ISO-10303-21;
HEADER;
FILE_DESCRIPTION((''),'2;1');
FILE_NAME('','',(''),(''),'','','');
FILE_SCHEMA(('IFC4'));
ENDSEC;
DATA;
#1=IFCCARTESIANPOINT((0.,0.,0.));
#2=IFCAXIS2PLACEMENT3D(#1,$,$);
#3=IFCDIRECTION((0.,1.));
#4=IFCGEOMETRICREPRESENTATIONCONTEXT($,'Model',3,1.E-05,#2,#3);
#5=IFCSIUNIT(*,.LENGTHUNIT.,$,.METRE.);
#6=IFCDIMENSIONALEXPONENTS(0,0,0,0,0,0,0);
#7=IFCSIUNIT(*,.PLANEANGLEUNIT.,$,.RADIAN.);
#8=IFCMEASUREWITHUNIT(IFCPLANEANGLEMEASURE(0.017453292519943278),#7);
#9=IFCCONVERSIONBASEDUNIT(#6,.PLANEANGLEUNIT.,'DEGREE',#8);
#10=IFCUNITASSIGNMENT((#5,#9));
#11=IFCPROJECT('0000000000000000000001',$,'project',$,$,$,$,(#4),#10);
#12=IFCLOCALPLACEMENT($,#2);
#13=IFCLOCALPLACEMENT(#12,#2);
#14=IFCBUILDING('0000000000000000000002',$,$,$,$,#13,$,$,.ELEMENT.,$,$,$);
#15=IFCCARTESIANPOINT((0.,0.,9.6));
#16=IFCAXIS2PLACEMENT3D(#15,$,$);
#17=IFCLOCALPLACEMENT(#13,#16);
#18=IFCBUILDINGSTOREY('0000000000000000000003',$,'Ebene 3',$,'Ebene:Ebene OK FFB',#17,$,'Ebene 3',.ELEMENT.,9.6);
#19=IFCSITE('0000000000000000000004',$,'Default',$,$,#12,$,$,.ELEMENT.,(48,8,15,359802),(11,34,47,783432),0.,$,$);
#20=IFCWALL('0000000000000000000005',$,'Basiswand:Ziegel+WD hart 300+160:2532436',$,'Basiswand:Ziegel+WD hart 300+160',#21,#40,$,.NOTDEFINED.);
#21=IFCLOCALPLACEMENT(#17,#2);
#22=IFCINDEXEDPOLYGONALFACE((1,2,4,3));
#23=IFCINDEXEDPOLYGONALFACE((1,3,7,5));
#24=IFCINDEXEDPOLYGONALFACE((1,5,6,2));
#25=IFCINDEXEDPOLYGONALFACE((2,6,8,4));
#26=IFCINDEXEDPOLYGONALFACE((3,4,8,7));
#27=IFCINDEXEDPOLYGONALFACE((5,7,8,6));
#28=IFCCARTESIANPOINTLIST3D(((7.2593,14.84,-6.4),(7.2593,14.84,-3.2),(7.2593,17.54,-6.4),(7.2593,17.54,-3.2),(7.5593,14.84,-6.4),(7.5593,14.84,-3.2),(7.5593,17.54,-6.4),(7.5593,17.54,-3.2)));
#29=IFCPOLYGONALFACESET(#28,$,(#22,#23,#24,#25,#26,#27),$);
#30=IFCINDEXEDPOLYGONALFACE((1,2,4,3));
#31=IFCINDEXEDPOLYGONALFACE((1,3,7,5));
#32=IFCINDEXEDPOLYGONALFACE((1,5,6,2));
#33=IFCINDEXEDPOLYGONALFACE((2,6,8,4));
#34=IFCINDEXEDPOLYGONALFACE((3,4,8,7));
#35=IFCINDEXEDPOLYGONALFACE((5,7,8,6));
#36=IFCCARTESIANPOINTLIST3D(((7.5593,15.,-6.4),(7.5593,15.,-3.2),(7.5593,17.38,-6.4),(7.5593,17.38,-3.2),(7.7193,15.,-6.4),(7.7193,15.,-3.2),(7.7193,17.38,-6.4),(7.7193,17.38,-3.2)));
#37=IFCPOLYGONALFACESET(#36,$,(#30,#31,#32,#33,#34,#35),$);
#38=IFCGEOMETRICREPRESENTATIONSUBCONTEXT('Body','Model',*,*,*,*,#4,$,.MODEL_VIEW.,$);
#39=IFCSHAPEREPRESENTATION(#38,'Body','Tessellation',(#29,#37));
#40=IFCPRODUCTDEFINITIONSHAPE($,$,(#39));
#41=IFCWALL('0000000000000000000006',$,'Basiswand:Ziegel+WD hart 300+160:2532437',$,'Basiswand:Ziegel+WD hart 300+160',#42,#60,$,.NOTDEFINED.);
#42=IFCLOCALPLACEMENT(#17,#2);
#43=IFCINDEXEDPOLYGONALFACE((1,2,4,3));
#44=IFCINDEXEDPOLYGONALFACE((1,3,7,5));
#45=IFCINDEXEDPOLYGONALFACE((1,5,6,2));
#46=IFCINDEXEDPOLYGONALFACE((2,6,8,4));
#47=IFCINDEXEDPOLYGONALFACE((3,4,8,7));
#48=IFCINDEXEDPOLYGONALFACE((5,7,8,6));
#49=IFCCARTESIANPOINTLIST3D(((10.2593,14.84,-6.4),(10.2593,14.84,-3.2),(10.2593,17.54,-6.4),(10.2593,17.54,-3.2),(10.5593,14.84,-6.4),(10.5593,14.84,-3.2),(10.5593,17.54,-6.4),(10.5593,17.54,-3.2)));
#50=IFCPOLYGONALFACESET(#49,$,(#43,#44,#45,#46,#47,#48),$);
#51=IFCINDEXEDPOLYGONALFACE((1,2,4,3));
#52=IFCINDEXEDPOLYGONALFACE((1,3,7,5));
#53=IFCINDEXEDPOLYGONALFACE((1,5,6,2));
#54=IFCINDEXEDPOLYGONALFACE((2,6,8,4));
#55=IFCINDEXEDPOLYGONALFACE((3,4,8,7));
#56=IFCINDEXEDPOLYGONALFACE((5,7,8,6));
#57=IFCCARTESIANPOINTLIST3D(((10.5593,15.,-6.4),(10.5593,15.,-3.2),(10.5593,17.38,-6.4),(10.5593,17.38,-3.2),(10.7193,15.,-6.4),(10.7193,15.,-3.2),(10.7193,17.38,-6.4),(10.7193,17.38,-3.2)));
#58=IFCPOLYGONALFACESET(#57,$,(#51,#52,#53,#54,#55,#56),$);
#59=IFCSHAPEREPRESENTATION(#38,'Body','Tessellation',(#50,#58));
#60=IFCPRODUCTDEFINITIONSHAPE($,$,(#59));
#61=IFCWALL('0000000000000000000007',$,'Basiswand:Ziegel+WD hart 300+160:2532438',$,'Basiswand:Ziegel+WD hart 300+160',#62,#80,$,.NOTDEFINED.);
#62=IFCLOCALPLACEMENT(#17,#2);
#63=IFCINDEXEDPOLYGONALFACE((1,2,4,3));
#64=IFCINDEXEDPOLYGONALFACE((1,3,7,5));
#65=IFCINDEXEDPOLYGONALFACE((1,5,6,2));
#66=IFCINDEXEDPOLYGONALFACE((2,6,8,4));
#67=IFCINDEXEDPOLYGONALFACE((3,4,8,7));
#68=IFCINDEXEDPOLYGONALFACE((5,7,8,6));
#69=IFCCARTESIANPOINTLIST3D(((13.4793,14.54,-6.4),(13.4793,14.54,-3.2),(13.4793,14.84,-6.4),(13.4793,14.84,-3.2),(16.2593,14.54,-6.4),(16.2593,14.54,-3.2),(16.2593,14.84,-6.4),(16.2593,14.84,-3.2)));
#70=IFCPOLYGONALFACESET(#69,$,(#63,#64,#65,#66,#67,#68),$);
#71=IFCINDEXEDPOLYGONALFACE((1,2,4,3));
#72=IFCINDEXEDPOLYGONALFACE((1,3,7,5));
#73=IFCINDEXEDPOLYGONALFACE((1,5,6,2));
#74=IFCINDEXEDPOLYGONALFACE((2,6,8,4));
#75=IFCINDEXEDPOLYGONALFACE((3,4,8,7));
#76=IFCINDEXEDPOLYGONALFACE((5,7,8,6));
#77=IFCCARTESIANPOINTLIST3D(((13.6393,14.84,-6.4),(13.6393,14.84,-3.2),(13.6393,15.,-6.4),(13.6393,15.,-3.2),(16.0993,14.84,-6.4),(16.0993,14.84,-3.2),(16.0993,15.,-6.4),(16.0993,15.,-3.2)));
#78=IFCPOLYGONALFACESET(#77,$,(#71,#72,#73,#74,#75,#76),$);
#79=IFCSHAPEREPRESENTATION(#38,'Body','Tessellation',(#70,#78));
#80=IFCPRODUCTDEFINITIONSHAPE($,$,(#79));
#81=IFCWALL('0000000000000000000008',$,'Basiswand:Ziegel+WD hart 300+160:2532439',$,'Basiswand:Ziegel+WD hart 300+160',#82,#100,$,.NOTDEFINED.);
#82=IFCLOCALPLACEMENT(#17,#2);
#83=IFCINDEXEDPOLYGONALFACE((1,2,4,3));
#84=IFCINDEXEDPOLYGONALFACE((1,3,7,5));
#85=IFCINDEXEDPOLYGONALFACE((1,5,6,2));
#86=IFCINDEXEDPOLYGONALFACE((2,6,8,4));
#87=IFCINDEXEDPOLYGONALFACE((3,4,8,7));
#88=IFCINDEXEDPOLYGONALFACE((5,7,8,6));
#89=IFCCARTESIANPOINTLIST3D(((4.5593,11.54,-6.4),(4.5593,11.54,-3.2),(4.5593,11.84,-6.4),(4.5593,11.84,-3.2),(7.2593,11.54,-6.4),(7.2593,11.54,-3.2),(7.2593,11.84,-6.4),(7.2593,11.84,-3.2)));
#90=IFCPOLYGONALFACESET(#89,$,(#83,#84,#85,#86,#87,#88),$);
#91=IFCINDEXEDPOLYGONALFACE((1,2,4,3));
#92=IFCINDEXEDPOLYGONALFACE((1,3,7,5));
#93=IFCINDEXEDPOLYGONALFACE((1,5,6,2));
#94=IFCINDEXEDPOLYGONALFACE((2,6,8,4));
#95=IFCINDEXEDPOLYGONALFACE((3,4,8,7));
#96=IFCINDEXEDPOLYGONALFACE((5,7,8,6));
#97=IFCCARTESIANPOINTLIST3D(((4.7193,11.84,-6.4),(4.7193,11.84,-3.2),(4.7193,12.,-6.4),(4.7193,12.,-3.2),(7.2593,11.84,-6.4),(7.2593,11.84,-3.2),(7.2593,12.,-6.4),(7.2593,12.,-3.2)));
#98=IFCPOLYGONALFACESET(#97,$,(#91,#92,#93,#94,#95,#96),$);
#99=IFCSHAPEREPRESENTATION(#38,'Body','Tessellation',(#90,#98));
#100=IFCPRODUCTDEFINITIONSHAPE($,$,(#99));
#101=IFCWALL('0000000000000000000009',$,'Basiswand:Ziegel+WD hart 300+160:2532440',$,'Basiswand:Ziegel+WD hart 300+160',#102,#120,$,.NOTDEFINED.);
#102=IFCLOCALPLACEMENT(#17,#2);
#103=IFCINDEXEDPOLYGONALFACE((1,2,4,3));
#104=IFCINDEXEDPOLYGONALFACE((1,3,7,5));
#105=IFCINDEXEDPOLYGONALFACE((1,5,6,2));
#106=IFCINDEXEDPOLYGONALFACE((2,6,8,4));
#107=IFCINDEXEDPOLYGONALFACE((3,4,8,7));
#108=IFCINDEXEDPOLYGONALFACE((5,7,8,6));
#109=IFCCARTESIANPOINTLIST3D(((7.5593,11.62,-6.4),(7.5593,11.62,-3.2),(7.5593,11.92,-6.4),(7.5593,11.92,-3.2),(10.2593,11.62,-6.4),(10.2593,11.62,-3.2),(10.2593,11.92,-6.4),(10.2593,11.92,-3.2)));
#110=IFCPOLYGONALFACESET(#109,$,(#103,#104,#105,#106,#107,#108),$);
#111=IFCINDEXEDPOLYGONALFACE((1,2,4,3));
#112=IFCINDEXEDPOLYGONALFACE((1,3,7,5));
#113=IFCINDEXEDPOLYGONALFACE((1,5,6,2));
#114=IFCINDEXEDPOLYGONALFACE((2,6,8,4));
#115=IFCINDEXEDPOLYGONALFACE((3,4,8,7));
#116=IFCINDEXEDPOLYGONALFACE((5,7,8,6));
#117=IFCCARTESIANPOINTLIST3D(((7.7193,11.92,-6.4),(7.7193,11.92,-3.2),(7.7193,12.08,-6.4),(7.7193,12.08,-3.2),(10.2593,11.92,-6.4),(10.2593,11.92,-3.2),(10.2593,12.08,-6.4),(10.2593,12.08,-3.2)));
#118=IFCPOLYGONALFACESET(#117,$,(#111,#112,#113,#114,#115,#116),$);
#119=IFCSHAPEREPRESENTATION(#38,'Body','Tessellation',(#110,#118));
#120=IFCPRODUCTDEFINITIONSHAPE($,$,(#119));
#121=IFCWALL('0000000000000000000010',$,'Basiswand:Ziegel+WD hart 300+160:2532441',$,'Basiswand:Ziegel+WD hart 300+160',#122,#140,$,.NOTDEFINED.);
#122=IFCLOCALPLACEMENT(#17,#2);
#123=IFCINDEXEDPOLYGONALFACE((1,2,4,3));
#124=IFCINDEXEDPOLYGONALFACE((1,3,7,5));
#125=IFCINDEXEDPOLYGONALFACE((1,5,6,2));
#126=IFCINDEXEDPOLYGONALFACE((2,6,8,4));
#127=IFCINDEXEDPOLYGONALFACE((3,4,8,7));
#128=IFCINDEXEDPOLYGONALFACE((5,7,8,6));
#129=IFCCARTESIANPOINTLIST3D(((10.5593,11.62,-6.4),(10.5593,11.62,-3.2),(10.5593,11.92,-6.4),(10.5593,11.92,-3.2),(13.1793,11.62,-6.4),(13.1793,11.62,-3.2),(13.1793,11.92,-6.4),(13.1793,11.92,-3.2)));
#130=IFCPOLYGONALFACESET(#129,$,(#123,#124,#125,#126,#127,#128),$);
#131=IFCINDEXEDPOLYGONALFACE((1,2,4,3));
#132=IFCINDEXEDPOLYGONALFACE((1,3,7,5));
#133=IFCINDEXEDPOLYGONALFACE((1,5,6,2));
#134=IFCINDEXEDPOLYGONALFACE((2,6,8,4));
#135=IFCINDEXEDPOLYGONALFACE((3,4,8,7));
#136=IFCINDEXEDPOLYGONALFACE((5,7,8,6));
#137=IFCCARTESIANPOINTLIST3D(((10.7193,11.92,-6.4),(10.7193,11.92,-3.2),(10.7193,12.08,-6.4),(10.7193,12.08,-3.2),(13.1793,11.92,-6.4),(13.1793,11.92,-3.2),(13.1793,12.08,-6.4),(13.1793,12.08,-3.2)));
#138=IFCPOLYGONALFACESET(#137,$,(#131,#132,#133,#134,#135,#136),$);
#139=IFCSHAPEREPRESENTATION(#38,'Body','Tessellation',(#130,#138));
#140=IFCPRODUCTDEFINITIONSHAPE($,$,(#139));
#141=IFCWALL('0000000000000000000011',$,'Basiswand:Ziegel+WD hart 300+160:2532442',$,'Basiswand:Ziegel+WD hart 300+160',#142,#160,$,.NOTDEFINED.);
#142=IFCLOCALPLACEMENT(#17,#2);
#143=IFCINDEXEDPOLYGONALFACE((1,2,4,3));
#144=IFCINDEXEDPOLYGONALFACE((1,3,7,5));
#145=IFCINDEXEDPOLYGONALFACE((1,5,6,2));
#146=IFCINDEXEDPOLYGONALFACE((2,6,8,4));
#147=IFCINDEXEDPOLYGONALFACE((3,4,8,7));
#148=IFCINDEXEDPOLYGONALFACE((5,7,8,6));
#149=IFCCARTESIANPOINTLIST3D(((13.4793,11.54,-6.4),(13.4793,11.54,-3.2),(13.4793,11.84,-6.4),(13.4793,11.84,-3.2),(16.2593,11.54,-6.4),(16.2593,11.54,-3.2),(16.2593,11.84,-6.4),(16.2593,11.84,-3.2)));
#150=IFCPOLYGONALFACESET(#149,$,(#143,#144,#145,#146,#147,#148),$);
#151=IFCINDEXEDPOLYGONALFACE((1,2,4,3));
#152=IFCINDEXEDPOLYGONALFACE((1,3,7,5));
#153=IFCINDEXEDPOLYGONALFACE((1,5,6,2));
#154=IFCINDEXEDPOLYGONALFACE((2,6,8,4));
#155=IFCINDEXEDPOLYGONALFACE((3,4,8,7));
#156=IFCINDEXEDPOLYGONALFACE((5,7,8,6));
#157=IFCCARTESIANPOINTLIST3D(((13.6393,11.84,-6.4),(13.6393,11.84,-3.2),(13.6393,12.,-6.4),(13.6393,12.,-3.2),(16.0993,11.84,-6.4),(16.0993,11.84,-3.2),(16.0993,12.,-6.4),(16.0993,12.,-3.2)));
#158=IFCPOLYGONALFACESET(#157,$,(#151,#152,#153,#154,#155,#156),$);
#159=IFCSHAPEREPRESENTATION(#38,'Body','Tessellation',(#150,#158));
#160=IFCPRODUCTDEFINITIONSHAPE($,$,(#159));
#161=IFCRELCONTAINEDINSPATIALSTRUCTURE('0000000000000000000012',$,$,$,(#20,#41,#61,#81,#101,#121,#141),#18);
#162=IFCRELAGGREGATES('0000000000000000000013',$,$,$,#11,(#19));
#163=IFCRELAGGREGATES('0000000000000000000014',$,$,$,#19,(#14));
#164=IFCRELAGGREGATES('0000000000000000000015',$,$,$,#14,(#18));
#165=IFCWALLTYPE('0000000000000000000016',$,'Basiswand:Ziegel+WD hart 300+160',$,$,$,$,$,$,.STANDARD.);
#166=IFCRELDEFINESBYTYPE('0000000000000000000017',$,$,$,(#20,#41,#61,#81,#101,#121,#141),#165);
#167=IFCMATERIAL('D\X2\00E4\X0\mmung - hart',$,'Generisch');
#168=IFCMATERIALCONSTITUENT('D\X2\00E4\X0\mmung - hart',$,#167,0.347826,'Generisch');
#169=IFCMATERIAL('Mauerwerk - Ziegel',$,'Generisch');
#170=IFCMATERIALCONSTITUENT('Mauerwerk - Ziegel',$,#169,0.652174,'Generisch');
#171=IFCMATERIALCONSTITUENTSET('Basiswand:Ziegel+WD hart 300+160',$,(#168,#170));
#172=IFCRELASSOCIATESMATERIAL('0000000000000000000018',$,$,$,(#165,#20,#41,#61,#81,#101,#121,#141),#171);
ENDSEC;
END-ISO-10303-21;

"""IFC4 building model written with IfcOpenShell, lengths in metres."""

from ifc_helpers import new_model, entity, si_unit, converted_unit, direction, frame, origin, place, context, subcontext, project, spatial, indexed_curve, outline, extrude, material, constituent, constituent_set, type_object, element, save


model = new_model("IFC4")

# Units and contexts
model_context = context("Model", 3, precision=1e-05, world=origin(), true_north=direction((0.0, 1.0)))
body_context = subcontext(model_context, "Body", "Model", "MODEL_VIEW")
ifc_project = project(units=[si_unit("LENGTHUNIT", "METRE"), converted_unit("PLANEANGLEUNIT", "DEGREE", entity("IfcPlaneAngleMeasure", 0.017453292519943278), si_unit("PLANEANGLEUNIT", "RADIAN"), dimensions=[0, 0, 0, 0, 0, 0, 0])], contexts=[model_context])

# Site, building, storey
site_placement = place(None, origin())
site = spatial("IfcSite", under=ifc_project, at=site_placement, Name="Default", CompositionType="ELEMENT", RefLatitude=(48, 8, 15, 359802), RefLongitude=(11, 34, 47, 783432), RefElevation=0.0)
building_placement = place(site_placement, origin())
building = spatial("IfcBuilding", under=site, at=building_placement, CompositionType="ELEMENT")
storey_placement = place(building_placement, frame((0.0, 0.0, 9.6)))
storey = spatial("IfcBuildingStorey", under=building, at=storey_placement, Name="Ebene 3", ObjectType="Ebene:Ebene OK FFB", LongName="Ebene 3", CompositionType="ELEMENT", Elevation=9.6)

# Walls
ifc_material_1 = material(Name="Dämmung - hart", Category="Generisch")
ifc_constituent_1 = constituent(ifc_material_1, Name="Dämmung - hart", Category="Generisch", fraction=0.347826)
ifc_material_2 = material(Name="Mauerwerk - Ziegel", Category="Generisch")
ifc_constituent_2 = constituent(ifc_material_2, Name="Mauerwerk - Ziegel", Category="Generisch", fraction=0.652174)
ifc_constituent_set = constituent_set(constituents=[ifc_constituent_1, ifc_constituent_2], Name="Basiswand:Ziegel+WD hart 300+160")
wall_type = type_object("IfcWallType", Name="Basiswand:Ziegel+WD hart 300+160", PredefinedType="STANDARD", material=ifc_constituent_set)
wall_1_placement = place(storey_placement, frame((7.4893, 17.38, -6.4), z_axis=(0.0, 0.0, 1.0), x_axis=(0.0, -1.0, 0.0)))
element("IfcWall", 1, at=wall_1_placement, inside=storey, type_object=wall_type, material=ifc_constituent_set, Name="Basiswand:Ziegel+WD hart 300+160:2532436", ObjectType="Basiswand:Ziegel+WD hart 300+160", PredefinedType="NOTDEFINED", context=body_context, shape_type="SweptSolid", body=[
    extrude(outline(indexed_curve([(-0.15, -1.35), (0.15, -1.35), (0.15, 1.35), (-0.15, 1.35), (-0.15, -1.35)], self_intersect=False)), frame((1.19, -0.08, 0.0), z_axis=(0.0, 0.0, 1.0), x_axis=(0.0, 1.0, 0.0)), (0.0, 0.0, 1.0), 3.2),
    extrude(outline(indexed_curve([(-0.08, -1.19), (0.08, -1.19), (0.08, 1.19), (-0.08, 1.19), (-0.08, -1.19)], self_intersect=False)), frame((1.19, 0.15, 0.0), z_axis=(0.0, 0.0, 1.0), x_axis=(0.0, -1.0, 0.0)), (0.0, 0.0, 1.0), 3.2),
])
wall_2_placement = place(storey_placement, frame((10.4893, 17.38, -6.4), z_axis=(0.0, 0.0, 1.0), x_axis=(0.0, -1.0, 0.0)))
element("IfcWall", 2, at=wall_2_placement, inside=storey, type_object=wall_type, material=ifc_constituent_set, Name="Basiswand:Ziegel+WD hart 300+160:2532437", ObjectType="Basiswand:Ziegel+WD hart 300+160", PredefinedType="NOTDEFINED", context=body_context, shape_type="SweptSolid", body=[
    extrude(outline(indexed_curve([(-0.15, -1.35), (0.15, -1.35), (0.15, 1.35), (-0.15, 1.35), (-0.15, -1.35)], self_intersect=False)), frame((1.19, -0.08, 0.0), z_axis=(0.0, 0.0, 1.0), x_axis=(0.0, 1.0, 0.0)), (0.0, 0.0, 1.0), 3.2),
    extrude(outline(indexed_curve([(-0.08, -1.19), (0.08, -1.19), (0.08, 1.19), (-0.08, 1.19), (-0.08, -1.19)], self_intersect=False)), frame((1.19, 0.15, 0.0), z_axis=(0.0, 0.0, 1.0), x_axis=(0.0, -1.0, 0.0)), (0.0, 0.0, 1.0), 3.2),
])
wall_3_placement = place(storey_placement, frame((13.6393, 14.77, -6.4)))
element("IfcWall", 3, at=wall_3_placement, inside=storey, type_object=wall_type, material=ifc_constituent_set, Name="Basiswand:Ziegel+WD hart 300+160:2532438", ObjectType="Basiswand:Ziegel+WD hart 300+160", PredefinedType="NOTDEFINED", context=body_context, shape_type="SweptSolid", body=[
    extrude(outline(indexed_curve([(-0.15, -1.39), (0.15, -1.39), (0.15, 1.39), (-0.15, 1.39), (-0.15, -1.39)], self_intersect=False)), frame((1.23, -0.08, 0.0), z_axis=(0.0, 0.0, 1.0), x_axis=(0.0, 1.0, 0.0)), (0.0, 0.0, 1.0), 3.2),
    extrude(outline(indexed_curve([(-0.08, -1.23), (0.08, -1.23), (0.08, 1.23), (-0.08, 1.23), (-0.08, -1.23)], self_intersect=False)), frame((1.23, 0.15, 0.0), z_axis=(0.0, 0.0, 1.0), x_axis=(0.0, -1.0, 0.0)), (0.0, 0.0, 1.0), 3.2),
])
wall_4_placement = place(storey_placement, frame((4.7193, 11.77, -6.4)))
element("IfcWall", 4, at=wall_4_placement, inside=storey, type_object=wall_type, material=ifc_constituent_set, Name="Basiswand:Ziegel+WD hart 300+160:2532439", ObjectType="Basiswand:Ziegel+WD hart 300+160", PredefinedType="NOTDEFINED", context=body_context, shape_type="SweptSolid", body=[
    extrude(outline(indexed_curve([(-0.15, -1.35), (0.15, -1.35), (0.15, 1.35), (-0.15, 1.35), (-0.15, -1.35)], self_intersect=False)), frame((1.19, -0.08, 0.0), z_axis=(0.0, 0.0, 1.0), x_axis=(0.0, 1.0, 0.0)), (0.0, 0.0, 1.0), 3.2),
    extrude(outline(indexed_curve([(-0.08, -1.27), (0.08, -1.27), (0.08, 1.27), (-0.08, 1.27), (-0.08, -1.27)], self_intersect=False)), frame((1.27, 0.15, 0.0), z_axis=(0.0, 0.0, 1.0), x_axis=(0.0, -1.0, 0.0)), (0.0, 0.0, 1.0), 3.2),
])
wall_5_placement = place(storey_placement, frame((7.7193, 11.85, -6.4)))
element("IfcWall", 5, at=wall_5_placement, inside=storey, type_object=wall_type, material=ifc_constituent_set, Name="Basiswand:Ziegel+WD hart 300+160:2532440", ObjectType="Basiswand:Ziegel+WD hart 300+160", PredefinedType="NOTDEFINED", context=body_context, shape_type="SweptSolid", body=[
    extrude(outline(indexed_curve([(-0.15, -1.35), (0.15, -1.35), (0.15, 1.35), (-0.15, 1.35), (-0.15, -1.35)], self_intersect=False)), frame((1.19, -0.08, 0.0), z_axis=(0.0, 0.0, 1.0), x_axis=(0.0, 1.0, 0.0)), (0.0, 0.0, 1.0), 3.2),
    extrude(outline(indexed_curve([(-0.08, -1.27), (0.08, -1.27), (0.08, 1.27), (-0.08, 1.27), (-0.08, -1.27)], self_intersect=False)), frame((1.27, 0.15, 0.0), z_axis=(0.0, 0.0, 1.0), x_axis=(0.0, -1.0, 0.0)), (0.0, 0.0, 1.0), 3.2),
])
wall_6_placement = place(storey_placement, frame((10.7193, 11.85, -6.4)))
element("IfcWall", 6, at=wall_6_placement, inside=storey, type_object=wall_type, material=ifc_constituent_set, Name="Basiswand:Ziegel+WD hart 300+160:2532441", ObjectType="Basiswand:Ziegel+WD hart 300+160", PredefinedType="NOTDEFINED", context=body_context, shape_type="SweptSolid", body=[
    extrude(outline(indexed_curve([(-0.15, -1.31), (0.15, -1.31), (0.15, 1.31), (-0.15, 1.31), (-0.15, -1.31)], self_intersect=False)), frame((1.15, -0.08, 0.0), z_axis=(0.0, 0.0, 1.0), x_axis=(0.0, 1.0, 0.0)), (0.0, 0.0, 1.0), 3.2),
    extrude(outline(indexed_curve([(-0.08, -1.23), (0.08, -1.23), (0.08, 1.23), (-0.08, 1.23), (-0.08, -1.23)], self_intersect=False)), frame((1.23, 0.15, 0.0), z_axis=(0.0, 0.0, 1.0), x_axis=(0.0, -1.0, 0.0)), (0.0, 0.0, 1.0), 3.2),
])
wall_7_placement = place(storey_placement, frame((13.6393, 11.77, -6.4)))
element("IfcWall", 7, at=wall_7_placement, inside=storey, type_object=wall_type, material=ifc_constituent_set, Name="Basiswand:Ziegel+WD hart 300+160:2532442", ObjectType="Basiswand:Ziegel+WD hart 300+160", PredefinedType="NOTDEFINED", context=body_context, shape_type="SweptSolid", body=[
    extrude(outline(indexed_curve([(-0.15, -1.39), (0.15, -1.39), (0.15, 1.39), (-0.15, 1.39), (-0.15, -1.39)], self_intersect=False)), frame((1.23, -0.08, 0.0), z_axis=(0.0, 0.0, 1.0), x_axis=(0.0, 1.0, 0.0)), (0.0, 0.0, 1.0), 3.2),
    extrude(outline(indexed_curve([(-0.08, -1.23), (0.08, -1.23), (0.08, 1.23), (-0.08, 1.23), (-0.08, -1.23)], self_intersect=False)), frame((1.23, 0.15, 0.0), z_axis=(0.0, 0.0, 1.0), x_axis=(0.0, -1.0, 0.0)), (0.0, 0.0, 1.0), 3.2),
])

save(model, "model.ifc")
